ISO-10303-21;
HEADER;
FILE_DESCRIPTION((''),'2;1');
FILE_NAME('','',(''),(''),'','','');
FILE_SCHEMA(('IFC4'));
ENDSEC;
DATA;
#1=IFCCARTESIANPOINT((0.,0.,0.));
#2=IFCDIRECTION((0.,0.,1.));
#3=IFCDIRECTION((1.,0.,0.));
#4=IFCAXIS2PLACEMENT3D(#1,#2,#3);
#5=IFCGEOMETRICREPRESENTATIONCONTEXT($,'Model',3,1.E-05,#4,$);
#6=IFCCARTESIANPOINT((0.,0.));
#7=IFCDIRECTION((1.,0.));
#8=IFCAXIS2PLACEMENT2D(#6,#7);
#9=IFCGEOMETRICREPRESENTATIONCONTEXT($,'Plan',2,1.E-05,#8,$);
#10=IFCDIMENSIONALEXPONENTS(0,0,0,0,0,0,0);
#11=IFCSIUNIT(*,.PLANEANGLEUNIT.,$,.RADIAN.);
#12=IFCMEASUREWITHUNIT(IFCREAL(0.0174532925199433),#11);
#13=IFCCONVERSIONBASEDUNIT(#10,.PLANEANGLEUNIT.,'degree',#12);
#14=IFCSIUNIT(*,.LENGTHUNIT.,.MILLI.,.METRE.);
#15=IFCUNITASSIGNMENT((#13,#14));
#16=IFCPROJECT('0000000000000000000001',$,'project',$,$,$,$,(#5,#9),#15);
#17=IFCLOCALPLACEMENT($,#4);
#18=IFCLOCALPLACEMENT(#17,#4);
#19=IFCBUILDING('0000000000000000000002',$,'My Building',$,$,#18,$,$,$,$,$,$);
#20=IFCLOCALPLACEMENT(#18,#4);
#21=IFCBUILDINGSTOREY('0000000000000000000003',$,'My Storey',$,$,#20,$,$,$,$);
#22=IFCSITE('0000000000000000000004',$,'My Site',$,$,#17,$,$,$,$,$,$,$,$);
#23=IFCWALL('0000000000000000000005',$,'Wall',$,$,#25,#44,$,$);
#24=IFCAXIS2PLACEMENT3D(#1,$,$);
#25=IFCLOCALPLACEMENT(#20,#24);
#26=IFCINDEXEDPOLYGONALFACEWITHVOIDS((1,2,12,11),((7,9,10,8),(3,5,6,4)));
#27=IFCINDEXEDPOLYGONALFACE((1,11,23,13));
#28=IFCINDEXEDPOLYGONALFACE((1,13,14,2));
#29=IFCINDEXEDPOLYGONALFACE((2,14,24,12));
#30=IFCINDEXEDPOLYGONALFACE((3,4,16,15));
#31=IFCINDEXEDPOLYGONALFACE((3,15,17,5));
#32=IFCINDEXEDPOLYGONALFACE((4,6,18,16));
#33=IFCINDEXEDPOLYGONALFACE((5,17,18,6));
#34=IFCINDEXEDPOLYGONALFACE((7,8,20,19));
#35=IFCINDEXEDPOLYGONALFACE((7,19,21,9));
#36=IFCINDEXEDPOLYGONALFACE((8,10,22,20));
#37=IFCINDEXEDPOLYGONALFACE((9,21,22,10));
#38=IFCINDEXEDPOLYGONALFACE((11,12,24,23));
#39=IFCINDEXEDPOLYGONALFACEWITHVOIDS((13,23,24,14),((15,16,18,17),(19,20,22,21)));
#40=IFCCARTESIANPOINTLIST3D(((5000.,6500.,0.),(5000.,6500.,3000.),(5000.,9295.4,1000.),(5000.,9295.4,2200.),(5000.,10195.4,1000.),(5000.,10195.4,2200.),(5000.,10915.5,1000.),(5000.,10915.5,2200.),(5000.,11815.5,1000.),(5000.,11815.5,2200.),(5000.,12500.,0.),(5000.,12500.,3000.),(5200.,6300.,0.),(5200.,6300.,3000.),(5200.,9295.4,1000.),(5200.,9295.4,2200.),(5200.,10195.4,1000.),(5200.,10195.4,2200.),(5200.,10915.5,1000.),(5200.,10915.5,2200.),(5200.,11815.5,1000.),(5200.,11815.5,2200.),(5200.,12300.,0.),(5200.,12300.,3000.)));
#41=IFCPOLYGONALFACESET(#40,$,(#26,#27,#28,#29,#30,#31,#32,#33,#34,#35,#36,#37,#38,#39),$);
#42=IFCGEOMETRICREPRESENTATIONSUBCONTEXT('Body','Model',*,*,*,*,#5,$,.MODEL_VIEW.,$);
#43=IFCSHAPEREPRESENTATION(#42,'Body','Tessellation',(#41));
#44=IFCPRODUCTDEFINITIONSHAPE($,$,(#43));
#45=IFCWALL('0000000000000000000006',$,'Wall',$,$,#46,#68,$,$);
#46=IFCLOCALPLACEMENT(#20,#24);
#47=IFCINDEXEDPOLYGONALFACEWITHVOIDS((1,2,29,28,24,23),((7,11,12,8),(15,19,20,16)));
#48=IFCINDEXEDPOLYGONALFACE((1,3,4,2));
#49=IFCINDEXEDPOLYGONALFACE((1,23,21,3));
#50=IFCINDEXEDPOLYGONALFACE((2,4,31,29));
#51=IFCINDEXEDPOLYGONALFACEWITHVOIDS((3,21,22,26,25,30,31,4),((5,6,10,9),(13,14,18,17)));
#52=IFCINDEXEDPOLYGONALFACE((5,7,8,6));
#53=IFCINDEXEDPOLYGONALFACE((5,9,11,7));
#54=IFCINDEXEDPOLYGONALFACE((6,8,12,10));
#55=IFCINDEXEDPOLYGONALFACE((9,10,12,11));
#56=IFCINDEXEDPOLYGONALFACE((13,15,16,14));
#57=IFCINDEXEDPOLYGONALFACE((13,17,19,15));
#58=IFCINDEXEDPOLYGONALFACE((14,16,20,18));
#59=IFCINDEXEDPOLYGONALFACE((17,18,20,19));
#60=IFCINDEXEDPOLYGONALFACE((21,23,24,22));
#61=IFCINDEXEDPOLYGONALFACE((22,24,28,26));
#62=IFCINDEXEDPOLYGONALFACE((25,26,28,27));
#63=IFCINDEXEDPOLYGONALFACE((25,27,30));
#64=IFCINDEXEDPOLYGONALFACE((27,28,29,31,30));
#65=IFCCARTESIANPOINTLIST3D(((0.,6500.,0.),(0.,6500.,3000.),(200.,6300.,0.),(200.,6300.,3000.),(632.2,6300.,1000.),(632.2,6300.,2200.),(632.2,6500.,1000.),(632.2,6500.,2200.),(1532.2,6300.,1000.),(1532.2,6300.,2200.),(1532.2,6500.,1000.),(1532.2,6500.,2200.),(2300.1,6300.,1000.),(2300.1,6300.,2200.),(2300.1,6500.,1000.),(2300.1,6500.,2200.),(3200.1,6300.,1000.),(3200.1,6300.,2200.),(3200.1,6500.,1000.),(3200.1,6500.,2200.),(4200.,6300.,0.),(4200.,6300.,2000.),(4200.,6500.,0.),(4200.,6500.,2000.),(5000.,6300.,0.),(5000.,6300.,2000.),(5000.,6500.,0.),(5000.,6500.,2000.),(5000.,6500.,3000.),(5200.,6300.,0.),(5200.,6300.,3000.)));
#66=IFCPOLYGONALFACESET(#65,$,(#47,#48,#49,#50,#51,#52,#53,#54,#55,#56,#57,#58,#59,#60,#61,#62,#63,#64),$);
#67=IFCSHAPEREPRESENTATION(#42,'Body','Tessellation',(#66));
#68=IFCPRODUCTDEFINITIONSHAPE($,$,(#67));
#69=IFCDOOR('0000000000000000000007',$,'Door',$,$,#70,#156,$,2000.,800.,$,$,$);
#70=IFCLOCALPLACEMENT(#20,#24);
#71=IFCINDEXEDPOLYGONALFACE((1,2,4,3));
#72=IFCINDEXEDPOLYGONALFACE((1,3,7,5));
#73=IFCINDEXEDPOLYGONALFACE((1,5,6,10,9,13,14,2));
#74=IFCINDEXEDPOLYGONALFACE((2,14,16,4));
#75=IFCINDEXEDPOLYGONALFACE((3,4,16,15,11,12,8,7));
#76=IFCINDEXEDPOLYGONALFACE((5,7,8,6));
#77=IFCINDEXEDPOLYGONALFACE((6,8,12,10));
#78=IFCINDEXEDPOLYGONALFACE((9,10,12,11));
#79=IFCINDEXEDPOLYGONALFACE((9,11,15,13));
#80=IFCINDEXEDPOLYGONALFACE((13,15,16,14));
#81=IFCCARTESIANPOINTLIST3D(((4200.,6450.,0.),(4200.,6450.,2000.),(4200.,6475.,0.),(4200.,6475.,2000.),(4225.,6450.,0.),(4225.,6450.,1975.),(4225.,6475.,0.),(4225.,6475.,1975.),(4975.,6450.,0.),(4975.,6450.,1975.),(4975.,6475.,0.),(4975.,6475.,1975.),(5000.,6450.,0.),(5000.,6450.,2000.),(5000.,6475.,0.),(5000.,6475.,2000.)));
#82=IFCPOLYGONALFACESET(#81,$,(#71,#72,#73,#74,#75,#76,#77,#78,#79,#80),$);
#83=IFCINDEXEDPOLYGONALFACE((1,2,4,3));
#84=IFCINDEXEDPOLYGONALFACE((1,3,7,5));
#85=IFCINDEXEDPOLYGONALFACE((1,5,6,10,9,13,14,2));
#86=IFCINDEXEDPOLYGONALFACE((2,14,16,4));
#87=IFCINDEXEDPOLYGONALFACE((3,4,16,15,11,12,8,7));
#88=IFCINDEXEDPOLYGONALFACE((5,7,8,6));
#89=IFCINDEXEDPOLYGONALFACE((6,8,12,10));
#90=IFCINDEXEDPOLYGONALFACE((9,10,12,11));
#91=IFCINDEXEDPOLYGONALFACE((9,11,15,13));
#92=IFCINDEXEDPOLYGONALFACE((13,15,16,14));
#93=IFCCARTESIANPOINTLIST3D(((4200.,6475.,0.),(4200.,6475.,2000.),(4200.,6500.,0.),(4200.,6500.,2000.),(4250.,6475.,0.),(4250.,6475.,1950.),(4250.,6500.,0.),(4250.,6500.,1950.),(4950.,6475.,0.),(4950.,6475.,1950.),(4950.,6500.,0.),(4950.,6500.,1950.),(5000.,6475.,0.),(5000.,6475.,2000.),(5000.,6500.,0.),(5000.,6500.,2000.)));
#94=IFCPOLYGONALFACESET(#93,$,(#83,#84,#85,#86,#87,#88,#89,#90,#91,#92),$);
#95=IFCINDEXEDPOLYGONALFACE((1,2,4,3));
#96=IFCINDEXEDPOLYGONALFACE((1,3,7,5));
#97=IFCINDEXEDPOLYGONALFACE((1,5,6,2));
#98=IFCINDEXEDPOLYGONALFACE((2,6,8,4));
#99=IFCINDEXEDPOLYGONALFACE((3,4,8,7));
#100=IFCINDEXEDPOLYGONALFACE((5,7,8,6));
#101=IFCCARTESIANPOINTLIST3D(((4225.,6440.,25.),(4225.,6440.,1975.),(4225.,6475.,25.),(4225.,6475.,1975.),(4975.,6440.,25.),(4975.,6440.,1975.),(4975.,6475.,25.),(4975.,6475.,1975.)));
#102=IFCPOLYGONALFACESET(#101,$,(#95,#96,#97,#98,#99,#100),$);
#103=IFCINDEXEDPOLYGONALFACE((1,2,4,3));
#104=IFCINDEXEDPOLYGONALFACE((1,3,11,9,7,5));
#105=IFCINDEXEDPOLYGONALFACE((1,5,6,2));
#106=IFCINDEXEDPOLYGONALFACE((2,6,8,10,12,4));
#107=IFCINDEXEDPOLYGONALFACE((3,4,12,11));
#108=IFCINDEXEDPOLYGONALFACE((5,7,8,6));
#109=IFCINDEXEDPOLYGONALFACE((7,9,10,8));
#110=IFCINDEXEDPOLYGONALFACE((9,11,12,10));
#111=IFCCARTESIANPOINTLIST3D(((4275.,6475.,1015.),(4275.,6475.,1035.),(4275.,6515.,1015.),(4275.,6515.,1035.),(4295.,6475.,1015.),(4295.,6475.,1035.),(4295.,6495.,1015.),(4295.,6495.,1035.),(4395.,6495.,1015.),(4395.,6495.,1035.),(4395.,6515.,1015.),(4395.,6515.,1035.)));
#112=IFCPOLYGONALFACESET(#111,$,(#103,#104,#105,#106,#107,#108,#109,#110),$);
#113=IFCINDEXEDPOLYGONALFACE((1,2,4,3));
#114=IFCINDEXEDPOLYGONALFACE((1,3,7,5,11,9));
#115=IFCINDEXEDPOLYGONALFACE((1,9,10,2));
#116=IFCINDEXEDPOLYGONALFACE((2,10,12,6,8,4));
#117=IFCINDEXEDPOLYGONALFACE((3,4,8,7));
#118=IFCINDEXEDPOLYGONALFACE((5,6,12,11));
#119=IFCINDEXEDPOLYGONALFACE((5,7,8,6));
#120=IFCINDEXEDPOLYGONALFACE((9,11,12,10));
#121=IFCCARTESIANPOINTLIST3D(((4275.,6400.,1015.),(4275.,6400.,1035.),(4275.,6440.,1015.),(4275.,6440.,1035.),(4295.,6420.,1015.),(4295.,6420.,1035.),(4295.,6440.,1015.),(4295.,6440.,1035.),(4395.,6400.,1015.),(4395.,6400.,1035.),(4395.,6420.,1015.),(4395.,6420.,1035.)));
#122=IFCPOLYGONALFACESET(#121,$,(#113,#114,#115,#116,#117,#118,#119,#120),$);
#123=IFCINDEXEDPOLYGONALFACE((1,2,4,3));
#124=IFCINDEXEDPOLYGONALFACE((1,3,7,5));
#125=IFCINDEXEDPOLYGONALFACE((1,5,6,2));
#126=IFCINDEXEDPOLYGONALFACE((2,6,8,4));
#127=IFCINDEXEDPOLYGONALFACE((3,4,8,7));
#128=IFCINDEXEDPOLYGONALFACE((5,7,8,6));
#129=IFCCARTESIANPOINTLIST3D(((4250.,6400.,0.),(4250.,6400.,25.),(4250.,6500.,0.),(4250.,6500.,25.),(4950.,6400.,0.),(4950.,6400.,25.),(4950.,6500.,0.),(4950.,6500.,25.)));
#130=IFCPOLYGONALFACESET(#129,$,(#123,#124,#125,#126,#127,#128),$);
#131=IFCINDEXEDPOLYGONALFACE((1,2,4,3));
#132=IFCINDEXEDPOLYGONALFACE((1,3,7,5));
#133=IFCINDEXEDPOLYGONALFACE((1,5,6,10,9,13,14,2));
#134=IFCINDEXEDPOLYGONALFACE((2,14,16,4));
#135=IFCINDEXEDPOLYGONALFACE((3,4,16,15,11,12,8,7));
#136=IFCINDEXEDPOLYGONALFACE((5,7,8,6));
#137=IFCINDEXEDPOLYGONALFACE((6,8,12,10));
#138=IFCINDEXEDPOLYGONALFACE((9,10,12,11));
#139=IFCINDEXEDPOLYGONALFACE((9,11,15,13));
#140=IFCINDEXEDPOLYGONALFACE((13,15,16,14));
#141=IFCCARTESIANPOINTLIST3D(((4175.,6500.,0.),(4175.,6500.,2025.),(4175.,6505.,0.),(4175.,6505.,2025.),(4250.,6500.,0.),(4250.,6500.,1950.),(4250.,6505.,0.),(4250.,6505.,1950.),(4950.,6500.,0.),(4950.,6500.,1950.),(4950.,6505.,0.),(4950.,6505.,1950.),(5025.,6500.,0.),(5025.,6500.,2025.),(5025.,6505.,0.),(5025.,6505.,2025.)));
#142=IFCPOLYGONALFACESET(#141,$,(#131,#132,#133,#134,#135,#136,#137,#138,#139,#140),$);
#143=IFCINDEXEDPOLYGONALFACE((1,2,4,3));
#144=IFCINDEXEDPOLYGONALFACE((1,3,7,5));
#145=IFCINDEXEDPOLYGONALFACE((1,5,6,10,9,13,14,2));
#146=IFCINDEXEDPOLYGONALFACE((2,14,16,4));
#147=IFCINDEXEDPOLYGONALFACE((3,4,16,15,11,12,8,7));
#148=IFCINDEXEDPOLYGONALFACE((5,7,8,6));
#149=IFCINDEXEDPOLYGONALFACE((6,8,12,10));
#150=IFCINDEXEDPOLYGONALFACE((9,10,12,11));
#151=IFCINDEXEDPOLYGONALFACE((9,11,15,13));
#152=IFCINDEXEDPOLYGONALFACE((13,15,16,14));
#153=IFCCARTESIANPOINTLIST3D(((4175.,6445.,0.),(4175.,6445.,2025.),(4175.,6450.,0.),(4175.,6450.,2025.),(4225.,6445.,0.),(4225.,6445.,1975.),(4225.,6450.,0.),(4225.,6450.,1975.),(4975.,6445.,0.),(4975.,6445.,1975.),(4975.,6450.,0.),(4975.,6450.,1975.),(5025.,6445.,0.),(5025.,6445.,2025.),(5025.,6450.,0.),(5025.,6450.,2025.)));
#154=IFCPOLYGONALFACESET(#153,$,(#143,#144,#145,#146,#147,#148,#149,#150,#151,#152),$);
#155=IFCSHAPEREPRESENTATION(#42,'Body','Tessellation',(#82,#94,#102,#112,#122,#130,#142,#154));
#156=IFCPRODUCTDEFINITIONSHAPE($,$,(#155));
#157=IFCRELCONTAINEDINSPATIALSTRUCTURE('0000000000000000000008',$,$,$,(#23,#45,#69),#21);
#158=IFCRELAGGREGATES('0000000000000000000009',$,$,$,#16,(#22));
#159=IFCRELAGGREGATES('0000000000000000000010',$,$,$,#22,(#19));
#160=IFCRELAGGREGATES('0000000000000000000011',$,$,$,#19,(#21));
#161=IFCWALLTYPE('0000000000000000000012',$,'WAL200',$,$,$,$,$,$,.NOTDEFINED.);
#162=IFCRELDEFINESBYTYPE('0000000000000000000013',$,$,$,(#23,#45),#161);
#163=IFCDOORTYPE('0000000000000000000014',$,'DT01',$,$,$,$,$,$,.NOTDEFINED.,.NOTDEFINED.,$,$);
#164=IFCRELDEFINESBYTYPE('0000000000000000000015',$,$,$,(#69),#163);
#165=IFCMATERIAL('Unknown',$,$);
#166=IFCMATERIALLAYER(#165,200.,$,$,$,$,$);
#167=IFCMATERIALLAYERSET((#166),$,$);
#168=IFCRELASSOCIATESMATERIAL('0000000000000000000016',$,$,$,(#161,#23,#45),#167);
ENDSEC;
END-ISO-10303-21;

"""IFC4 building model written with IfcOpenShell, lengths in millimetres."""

from ifc_helpers import new_model, entity, si_unit, converted_unit, frame, origin_with_axes, origin_2d_with_axis, place, context, subcontext, project, spatial, line, indexed_curve, outline, extrude, clip, halfspace, shape, source, transform, mapped, material, layer, layer_set, layer_usage, type_object, type_shapes, element, fill, save


model = new_model("IFC4")

# Units and contexts
model_context = context("Model", 3, precision=1e-05, world=origin_with_axes())
plan_context = context("Plan", 2, precision=1e-05, world=origin_2d_with_axis())
body_context_1 = subcontext(model_context, "Body", "Model", "MODEL_VIEW")
body_context_2 = subcontext(plan_context, "Body", "Plan", "PLAN_VIEW")
ifc_project = project(units=[converted_unit("PLANEANGLEUNIT", "degree", entity("IfcReal", 0.0174532925199433), si_unit("PLANEANGLEUNIT", "RADIAN"), dimensions=[0, 0, 0, 0, 0, 0, 0]), si_unit("LENGTHUNIT", "METRE", prefix="MILLI")], contexts=[model_context, plan_context])

# Site, building, storey
site_placement = place(None, origin_with_axes())
site = spatial("IfcSite", under=ifc_project, at=site_placement, Name="My Site")
building_placement = place(site_placement, origin_with_axes())
building = spatial("IfcBuilding", under=site, at=building_placement, Name="My Building")
storey_placement = place(building_placement, origin_with_axes())
storey = spatial("IfcBuildingStorey", under=building, at=storey_placement, Name="My Storey")

# Shared definitions
ifc_material = material(Name="Unknown")

# Shared definitions
shared_shape_1 = source(origin_with_axes(), body_context_1, "Body", "SolidModel", [
    extrude(outline(indexed_curve([(0.0, 0.0), (800.0, 0.0), (800.0, 2000.0), (0.0, 2000.0)], segments=[line(1, 2, 3, 4, 1)])), frame((0.0, -600.0, 0.0), z_axis=(0.0, -1.0, 0.0), x_axis=(1.0, 0.0, 0.0)), (0.0, 0.0, -1.0), 1200.0),
])
door_type = type_object("IfcDoorType", Name="DT01", OperationType="NOTDEFINED", PredefinedType="NOTDEFINED")
shared_shape_2 = source(origin_with_axes(), body_context_1, "Body", "SolidModel", [
    extrude(outline(indexed_curve([(0.0, 0.0), (0.0, 2000.0), (800.0, 2000.0), (800.0, 0.0), (775.0, 0.0), (775.0, 1975.0), (25.0, 1975.0), (25.0, 0.0)], segments=[line(1, 2, 3, 4, 5, 6, 7, 8, 1)])), frame((0.0, 25.0, 0.0), z_axis=(0.0, -1.0, 0.0), x_axis=(1.0, 0.0, 0.0)), (0.0, 0.0, -1.0), 25.0),
    extrude(outline(indexed_curve([(0.0, 0.0), (0.0, 2000.0), (800.0, 2000.0), (800.0, 0.0), (750.0, 0.0), (750.0, 1950.0), (50.0, 1950.0), (50.0, 0.0)], segments=[line(1, 2, 3, 4, 5, 6, 7, 8, 1)])), frame((0.0, 0.0, 0.0), z_axis=(0.0, -1.0, 0.0), x_axis=(1.0, 0.0, 0.0)), (0.0, 0.0, -1.0), 25.0),
    extrude(outline(indexed_curve([(0.0, 0.0), (750.0, 0.0), (750.0, 35.0), (0.0, 35.0)], segments=[line(1, 2, 3, 4, 1)])), frame((25.0, 25.0, 25.0), z_axis=(0.0, 0.0, 1.0), x_axis=(1.0, 0.0, 0.0)), (0.0, 0.0, 1.0), 1950.0),
    extrude(outline(indexed_curve([(0.0, 0.0), (0.0, -40.0), (-120.0, -40.0), (-120.0, -20.0), (-20.0, -20.0), (-20.0, 0.0)], segments=[line(1, 2, 3, 4, 5, 6, 1)])), frame((725.0, 25.0, 1015.0), z_axis=(0.0, 0.0, 1.0), x_axis=(1.0, 0.0, 0.0)), (0.0, 0.0, 1.0), 20.0),
    extrude(outline(indexed_curve([(0.0, 0.0), (0.0, 40.0), (-120.0, 40.0), (-120.0, 20.0), (-20.0, 20.0), (-20.0, 0.0)], segments=[line(1, 2, 3, 4, 5, 6, 1)])), frame((725.0, 60.0, 1015.0), z_axis=(0.0, 0.0, 1.0), x_axis=(1.0, 0.0, 0.0)), (0.0, 0.0, 1.0), 20.0),
    extrude(outline(indexed_curve([(0.0, 0.0), (700.0, 0.0), (700.0, 100.0), (0.0, 100.0)], segments=[line(1, 2, 3, 4, 1)])), frame((50.0, 0.0, 0.0), z_axis=(0.0, 0.0, 1.0), x_axis=(1.0, 0.0, 0.0)), (0.0, 0.0, 1.0), 25.0),
    extrude(outline(indexed_curve([(0.0, 0.0), (0.0, 2025.0), (850.0, 2025.0), (850.0, 0.0), (775.0, 0.0), (775.0, 1950.0), (75.0, 1950.0), (75.0, 0.0)], segments=[line(1, 2, 3, 4, 5, 6, 7, 8, 1)])), frame((-25.0, -5.0, 0.0), z_axis=(0.0, -1.0, 0.0), x_axis=(1.0, 0.0, 0.0)), (0.0, 0.0, -1.0), 5.0),
    extrude(outline(indexed_curve([(0.0, 0.0), (0.0, 2025.0), (850.0, 2025.0), (850.0, 0.0), (800.0, 0.0), (800.0, 1975.0), (50.0, 1975.0), (50.0, 0.0)], segments=[line(1, 2, 3, 4, 5, 6, 7, 8, 1)])), frame((-25.0, 50.0, 0.0), z_axis=(0.0, -1.0, 0.0), x_axis=(1.0, 0.0, 0.0)), (0.0, 0.0, -1.0), 5.0),
])
shared_shape_3 = source(origin_with_axes(), body_context_2, "Body", "Curve2D", [
    entity("IfcIndexedPolyCurve", entity("IfcCartesianPointList2D", [[0.0, 0.0], [0.0, 50.0], [25.0, 50.0], [25.0, 25.0], [50.0, 25.0], [50.0, 0.0]]), [entity("IfcLineIndex", [1, 2, 3, 4, 5, 6, 1])]),
    entity("IfcIndexedPolyCurve", entity("IfcCartesianPointList2D", [[800.0, 0.0], [800.0, 50.0], [775.0, 50.0], [775.0, 25.0], [750.0, 25.0], [750.0, 0.0]]), [entity("IfcLineIndex", [1, 2, 3, 4, 5, 6, 1])]),
    entity("IfcTrimmedCurve", entity("IfcEllipse", entity("IfcAxis2Placement2D", entity("IfcCartesianPoint", [60.0, 50.0]), entity("IfcDirection", [1.0, 0.0])), 715.0, 750.0), [entity("IfcCartesianPoint", [775.0, 50.0])], [entity("IfcCartesianPoint", [60.0, 800.0])], True, "CARTESIAN"),
    entity("IfcIndexedPolyCurve", entity("IfcCartesianPointList2D", [[25.0, 50.0], [60.0, 50.0], [60.0, 800.0], [25.0, 800.0]]), [entity("IfcLineIndex", [1, 2, 3, 4, 1])]),
])
type_shapes(door_type, [shared_shape_2, shared_shape_3])

# Shared definitions
ifc_layer_1 = layer(ifc_material, 200.0)
ifc_layer_set_1 = layer_set([ifc_layer_1])
wall_type_1 = type_object("IfcWallType", Name="WAL200", PredefinedType="NOTDEFINED", material=ifc_layer_set_1)

# Wall, openings
ifc_layer_usage_1 = layer_usage(ifc_layer_set_1, "AXIS2", "POSITIVE", 0.0)
wall_1_placement = place(storey_placement, frame((5000.0, 12500.0, 0.0), z_axis=(0.0, 0.0, 1.0), x_axis=(0.0, -1.0, 0.0)))
wall_1 = element("IfcWall", 1, at=wall_1_placement, inside=storey, type_object=wall_type_1, material=ifc_layer_usage_1, Name="Wall", context=body_context_1, shape_type="Clipping", body=[
    clip(clip(extrude(outline(indexed_curve([(0.0, 0.0), (0.0, 200.0), (6200.0, 200.0), (6200.0, 0.0), (0.0, 0.0)], self_intersect=False)), origin_with_axes(), (0.0, 0.0, 1.0), 3000.0), halfspace(frame((6000.0, 0.0, 0.0), z_axis=(0.707107, -0.707107, 0.0), x_axis=(-0.707107, -0.707107, 0.0)), False)), halfspace(frame((0.0, 0.0, 0.0), z_axis=(-0.707107, 0.707107, 0.0), x_axis=(0.707107, 0.707107, 0.0)), False)),
])
shared_shape_4 = source(origin_with_axes(), body_context_1, "Body", "SolidModel", [
    extrude(outline(indexed_curve([(0.0, 0.0), (900.0, 0.0), (900.0, 1200.0), (0.0, 1200.0)], segments=[line(1, 2, 3, 4, 1)])), frame((0.0, -600.0, 0.0), z_axis=(0.0, -1.0, 0.0), x_axis=(1.0, 0.0, 0.0)), (0.0, 0.0, -1.0), 1200.0),
])
opening_1_placement = place(wall_1_placement, frame((684.5, 0.0, 1000.0), z_axis=(0.0, 0.0, 1.0), x_axis=(1.0, 0.0, 0.0)))
element("IfcOpeningElement", 2, at=opening_1_placement, cuts=wall_1, PredefinedType="OPENING", context=body_context_1, shape_type="MappedRepresentation", body=[
    mapped(shared_shape_4, transform((0.0, 0.0, 0.0), x_axis=(1.0, 0.0, 0.0), y_axis=(0.0, 1.0, 0.0), z_axis=(0.0, 0.0, 1.0), scale=1.0)),
])
opening_2_placement = place(wall_1_placement, frame((2304.6, 0.0, 1000.0), z_axis=(0.0, 0.0, 1.0), x_axis=(1.0, 0.0, 0.0)))
element("IfcOpeningElement", 3, at=opening_2_placement, cuts=wall_1, PredefinedType="OPENING", context=body_context_1, shape_type="MappedRepresentation", body=[
    mapped(shared_shape_4, transform((0.0, 0.0, 0.0), x_axis=(1.0, 0.0, 0.0), y_axis=(0.0, 1.0, 0.0), z_axis=(0.0, 0.0, 1.0), scale=1.0)),
])

# Wall, openings, door
ifc_layer_usage_2 = layer_usage(ifc_layer_set_1, "AXIS2", "POSITIVE", 0.0)
wall_2_placement = place(storey_placement, frame((5200.0, 6500.0, 0.0), z_axis=(0.0, 0.0, 1.0), x_axis=(-1.0, 0.0, 0.0)))
wall_2 = element("IfcWall", 4, at=wall_2_placement, inside=storey, type_object=wall_type_1, material=ifc_layer_usage_2, Name="Wall", context=body_context_1, shape_type="Clipping", body=[
    clip(clip(extrude(outline(indexed_curve([(0.0, 0.0), (0.0, 200.0), (5200.0, 200.0), (5200.0, 0.0), (0.0, 0.0)], self_intersect=False)), origin_with_axes(), (0.0, 0.0, 1.0), 3000.0), halfspace(frame((5200.0, 0.0, 0.0), z_axis=(0.707106, 0.707107, 0.0), x_axis=(0.707107, -0.707106, 0.0)), False)), halfspace(frame((200.0, 0.0, 0.0), z_axis=(-0.707107, -0.707107, 0.0), x_axis=(-0.707107, 0.707107, 0.0)), False)),
])
opening_3_placement = place(wall_2_placement, frame((200.0, 0.0, 0.0), z_axis=(0.0, 0.0, 1.0), x_axis=(1.0, 0.0, 0.0)))
opening_3 = element("IfcOpeningElement", 5, at=opening_3_placement, cuts=wall_2, PredefinedType="OPENING", context=body_context_1, shape_type="MappedRepresentation", body=[
    mapped(shared_shape_1, transform((0.0, 0.0, 0.0), x_axis=(1.0, 0.0, 0.0), y_axis=(0.0, 1.0, 0.0), z_axis=(0.0, 0.0, 1.0), scale=1.0)),
])
opening_4_placement = place(wall_2_placement, frame((1999.9, 0.0, 1000.0), z_axis=(0.0, 0.0, 1.0), x_axis=(1.0, 0.0, 0.0)))
element("IfcOpeningElement", 6, at=opening_4_placement, cuts=wall_2, PredefinedType="OPENING", context=body_context_1, shape_type="MappedRepresentation", body=[
    mapped(shared_shape_4, transform((0.0, 0.0, 0.0), x_axis=(1.0, 0.0, 0.0), y_axis=(0.0, 1.0, 0.0), z_axis=(0.0, 0.0, 1.0), scale=1.0)),
])
opening_5_placement = place(wall_2_placement, frame((3667.8, 0.0, 1000.0), z_axis=(0.0, 0.0, 1.0), x_axis=(1.0, 0.0, 0.0)))
element("IfcOpeningElement", 7, at=opening_5_placement, cuts=wall_2, PredefinedType="OPENING", context=body_context_1, shape_type="MappedRepresentation", body=[
    mapped(shared_shape_4, transform((0.0, 0.0, 0.0), x_axis=(1.0, 0.0, 0.0), y_axis=(0.0, 1.0, 0.0), z_axis=(0.0, 0.0, 1.0), scale=1.0)),
])
door_1_placement = place(opening_3_placement, frame((0.0, 0.0, 0.0), z_axis=(0.0, 0.0, 1.0), x_axis=(1.0, 0.0, 0.0)))
door_1 = element("IfcDoor", 8, at=door_1_placement, inside=storey, type_object=door_type, Name="Door", OverallHeight=2000.0, OverallWidth=800.0, shapes=[
    shape(body_context_1, "Body", "MappedRepresentation", [mapped(shared_shape_2, transform((0.0, 0.0, 0.0), x_axis=(1.0, 0.0, 0.0), y_axis=(0.0, 1.0, 0.0), z_axis=(0.0, 0.0, 1.0), scale=1.0))]),
    shape(body_context_2, "Body", "MappedRepresentation", [mapped(shared_shape_3, transform((0.0, 0.0, 0.0), x_axis=(1.0, 0.0, 0.0), y_axis=(0.0, 1.0, 0.0), z_axis=(0.0, 0.0, 1.0), scale=1.0))]),
])
fill(opening_3, door_1)

save(model, "model.ifc")
